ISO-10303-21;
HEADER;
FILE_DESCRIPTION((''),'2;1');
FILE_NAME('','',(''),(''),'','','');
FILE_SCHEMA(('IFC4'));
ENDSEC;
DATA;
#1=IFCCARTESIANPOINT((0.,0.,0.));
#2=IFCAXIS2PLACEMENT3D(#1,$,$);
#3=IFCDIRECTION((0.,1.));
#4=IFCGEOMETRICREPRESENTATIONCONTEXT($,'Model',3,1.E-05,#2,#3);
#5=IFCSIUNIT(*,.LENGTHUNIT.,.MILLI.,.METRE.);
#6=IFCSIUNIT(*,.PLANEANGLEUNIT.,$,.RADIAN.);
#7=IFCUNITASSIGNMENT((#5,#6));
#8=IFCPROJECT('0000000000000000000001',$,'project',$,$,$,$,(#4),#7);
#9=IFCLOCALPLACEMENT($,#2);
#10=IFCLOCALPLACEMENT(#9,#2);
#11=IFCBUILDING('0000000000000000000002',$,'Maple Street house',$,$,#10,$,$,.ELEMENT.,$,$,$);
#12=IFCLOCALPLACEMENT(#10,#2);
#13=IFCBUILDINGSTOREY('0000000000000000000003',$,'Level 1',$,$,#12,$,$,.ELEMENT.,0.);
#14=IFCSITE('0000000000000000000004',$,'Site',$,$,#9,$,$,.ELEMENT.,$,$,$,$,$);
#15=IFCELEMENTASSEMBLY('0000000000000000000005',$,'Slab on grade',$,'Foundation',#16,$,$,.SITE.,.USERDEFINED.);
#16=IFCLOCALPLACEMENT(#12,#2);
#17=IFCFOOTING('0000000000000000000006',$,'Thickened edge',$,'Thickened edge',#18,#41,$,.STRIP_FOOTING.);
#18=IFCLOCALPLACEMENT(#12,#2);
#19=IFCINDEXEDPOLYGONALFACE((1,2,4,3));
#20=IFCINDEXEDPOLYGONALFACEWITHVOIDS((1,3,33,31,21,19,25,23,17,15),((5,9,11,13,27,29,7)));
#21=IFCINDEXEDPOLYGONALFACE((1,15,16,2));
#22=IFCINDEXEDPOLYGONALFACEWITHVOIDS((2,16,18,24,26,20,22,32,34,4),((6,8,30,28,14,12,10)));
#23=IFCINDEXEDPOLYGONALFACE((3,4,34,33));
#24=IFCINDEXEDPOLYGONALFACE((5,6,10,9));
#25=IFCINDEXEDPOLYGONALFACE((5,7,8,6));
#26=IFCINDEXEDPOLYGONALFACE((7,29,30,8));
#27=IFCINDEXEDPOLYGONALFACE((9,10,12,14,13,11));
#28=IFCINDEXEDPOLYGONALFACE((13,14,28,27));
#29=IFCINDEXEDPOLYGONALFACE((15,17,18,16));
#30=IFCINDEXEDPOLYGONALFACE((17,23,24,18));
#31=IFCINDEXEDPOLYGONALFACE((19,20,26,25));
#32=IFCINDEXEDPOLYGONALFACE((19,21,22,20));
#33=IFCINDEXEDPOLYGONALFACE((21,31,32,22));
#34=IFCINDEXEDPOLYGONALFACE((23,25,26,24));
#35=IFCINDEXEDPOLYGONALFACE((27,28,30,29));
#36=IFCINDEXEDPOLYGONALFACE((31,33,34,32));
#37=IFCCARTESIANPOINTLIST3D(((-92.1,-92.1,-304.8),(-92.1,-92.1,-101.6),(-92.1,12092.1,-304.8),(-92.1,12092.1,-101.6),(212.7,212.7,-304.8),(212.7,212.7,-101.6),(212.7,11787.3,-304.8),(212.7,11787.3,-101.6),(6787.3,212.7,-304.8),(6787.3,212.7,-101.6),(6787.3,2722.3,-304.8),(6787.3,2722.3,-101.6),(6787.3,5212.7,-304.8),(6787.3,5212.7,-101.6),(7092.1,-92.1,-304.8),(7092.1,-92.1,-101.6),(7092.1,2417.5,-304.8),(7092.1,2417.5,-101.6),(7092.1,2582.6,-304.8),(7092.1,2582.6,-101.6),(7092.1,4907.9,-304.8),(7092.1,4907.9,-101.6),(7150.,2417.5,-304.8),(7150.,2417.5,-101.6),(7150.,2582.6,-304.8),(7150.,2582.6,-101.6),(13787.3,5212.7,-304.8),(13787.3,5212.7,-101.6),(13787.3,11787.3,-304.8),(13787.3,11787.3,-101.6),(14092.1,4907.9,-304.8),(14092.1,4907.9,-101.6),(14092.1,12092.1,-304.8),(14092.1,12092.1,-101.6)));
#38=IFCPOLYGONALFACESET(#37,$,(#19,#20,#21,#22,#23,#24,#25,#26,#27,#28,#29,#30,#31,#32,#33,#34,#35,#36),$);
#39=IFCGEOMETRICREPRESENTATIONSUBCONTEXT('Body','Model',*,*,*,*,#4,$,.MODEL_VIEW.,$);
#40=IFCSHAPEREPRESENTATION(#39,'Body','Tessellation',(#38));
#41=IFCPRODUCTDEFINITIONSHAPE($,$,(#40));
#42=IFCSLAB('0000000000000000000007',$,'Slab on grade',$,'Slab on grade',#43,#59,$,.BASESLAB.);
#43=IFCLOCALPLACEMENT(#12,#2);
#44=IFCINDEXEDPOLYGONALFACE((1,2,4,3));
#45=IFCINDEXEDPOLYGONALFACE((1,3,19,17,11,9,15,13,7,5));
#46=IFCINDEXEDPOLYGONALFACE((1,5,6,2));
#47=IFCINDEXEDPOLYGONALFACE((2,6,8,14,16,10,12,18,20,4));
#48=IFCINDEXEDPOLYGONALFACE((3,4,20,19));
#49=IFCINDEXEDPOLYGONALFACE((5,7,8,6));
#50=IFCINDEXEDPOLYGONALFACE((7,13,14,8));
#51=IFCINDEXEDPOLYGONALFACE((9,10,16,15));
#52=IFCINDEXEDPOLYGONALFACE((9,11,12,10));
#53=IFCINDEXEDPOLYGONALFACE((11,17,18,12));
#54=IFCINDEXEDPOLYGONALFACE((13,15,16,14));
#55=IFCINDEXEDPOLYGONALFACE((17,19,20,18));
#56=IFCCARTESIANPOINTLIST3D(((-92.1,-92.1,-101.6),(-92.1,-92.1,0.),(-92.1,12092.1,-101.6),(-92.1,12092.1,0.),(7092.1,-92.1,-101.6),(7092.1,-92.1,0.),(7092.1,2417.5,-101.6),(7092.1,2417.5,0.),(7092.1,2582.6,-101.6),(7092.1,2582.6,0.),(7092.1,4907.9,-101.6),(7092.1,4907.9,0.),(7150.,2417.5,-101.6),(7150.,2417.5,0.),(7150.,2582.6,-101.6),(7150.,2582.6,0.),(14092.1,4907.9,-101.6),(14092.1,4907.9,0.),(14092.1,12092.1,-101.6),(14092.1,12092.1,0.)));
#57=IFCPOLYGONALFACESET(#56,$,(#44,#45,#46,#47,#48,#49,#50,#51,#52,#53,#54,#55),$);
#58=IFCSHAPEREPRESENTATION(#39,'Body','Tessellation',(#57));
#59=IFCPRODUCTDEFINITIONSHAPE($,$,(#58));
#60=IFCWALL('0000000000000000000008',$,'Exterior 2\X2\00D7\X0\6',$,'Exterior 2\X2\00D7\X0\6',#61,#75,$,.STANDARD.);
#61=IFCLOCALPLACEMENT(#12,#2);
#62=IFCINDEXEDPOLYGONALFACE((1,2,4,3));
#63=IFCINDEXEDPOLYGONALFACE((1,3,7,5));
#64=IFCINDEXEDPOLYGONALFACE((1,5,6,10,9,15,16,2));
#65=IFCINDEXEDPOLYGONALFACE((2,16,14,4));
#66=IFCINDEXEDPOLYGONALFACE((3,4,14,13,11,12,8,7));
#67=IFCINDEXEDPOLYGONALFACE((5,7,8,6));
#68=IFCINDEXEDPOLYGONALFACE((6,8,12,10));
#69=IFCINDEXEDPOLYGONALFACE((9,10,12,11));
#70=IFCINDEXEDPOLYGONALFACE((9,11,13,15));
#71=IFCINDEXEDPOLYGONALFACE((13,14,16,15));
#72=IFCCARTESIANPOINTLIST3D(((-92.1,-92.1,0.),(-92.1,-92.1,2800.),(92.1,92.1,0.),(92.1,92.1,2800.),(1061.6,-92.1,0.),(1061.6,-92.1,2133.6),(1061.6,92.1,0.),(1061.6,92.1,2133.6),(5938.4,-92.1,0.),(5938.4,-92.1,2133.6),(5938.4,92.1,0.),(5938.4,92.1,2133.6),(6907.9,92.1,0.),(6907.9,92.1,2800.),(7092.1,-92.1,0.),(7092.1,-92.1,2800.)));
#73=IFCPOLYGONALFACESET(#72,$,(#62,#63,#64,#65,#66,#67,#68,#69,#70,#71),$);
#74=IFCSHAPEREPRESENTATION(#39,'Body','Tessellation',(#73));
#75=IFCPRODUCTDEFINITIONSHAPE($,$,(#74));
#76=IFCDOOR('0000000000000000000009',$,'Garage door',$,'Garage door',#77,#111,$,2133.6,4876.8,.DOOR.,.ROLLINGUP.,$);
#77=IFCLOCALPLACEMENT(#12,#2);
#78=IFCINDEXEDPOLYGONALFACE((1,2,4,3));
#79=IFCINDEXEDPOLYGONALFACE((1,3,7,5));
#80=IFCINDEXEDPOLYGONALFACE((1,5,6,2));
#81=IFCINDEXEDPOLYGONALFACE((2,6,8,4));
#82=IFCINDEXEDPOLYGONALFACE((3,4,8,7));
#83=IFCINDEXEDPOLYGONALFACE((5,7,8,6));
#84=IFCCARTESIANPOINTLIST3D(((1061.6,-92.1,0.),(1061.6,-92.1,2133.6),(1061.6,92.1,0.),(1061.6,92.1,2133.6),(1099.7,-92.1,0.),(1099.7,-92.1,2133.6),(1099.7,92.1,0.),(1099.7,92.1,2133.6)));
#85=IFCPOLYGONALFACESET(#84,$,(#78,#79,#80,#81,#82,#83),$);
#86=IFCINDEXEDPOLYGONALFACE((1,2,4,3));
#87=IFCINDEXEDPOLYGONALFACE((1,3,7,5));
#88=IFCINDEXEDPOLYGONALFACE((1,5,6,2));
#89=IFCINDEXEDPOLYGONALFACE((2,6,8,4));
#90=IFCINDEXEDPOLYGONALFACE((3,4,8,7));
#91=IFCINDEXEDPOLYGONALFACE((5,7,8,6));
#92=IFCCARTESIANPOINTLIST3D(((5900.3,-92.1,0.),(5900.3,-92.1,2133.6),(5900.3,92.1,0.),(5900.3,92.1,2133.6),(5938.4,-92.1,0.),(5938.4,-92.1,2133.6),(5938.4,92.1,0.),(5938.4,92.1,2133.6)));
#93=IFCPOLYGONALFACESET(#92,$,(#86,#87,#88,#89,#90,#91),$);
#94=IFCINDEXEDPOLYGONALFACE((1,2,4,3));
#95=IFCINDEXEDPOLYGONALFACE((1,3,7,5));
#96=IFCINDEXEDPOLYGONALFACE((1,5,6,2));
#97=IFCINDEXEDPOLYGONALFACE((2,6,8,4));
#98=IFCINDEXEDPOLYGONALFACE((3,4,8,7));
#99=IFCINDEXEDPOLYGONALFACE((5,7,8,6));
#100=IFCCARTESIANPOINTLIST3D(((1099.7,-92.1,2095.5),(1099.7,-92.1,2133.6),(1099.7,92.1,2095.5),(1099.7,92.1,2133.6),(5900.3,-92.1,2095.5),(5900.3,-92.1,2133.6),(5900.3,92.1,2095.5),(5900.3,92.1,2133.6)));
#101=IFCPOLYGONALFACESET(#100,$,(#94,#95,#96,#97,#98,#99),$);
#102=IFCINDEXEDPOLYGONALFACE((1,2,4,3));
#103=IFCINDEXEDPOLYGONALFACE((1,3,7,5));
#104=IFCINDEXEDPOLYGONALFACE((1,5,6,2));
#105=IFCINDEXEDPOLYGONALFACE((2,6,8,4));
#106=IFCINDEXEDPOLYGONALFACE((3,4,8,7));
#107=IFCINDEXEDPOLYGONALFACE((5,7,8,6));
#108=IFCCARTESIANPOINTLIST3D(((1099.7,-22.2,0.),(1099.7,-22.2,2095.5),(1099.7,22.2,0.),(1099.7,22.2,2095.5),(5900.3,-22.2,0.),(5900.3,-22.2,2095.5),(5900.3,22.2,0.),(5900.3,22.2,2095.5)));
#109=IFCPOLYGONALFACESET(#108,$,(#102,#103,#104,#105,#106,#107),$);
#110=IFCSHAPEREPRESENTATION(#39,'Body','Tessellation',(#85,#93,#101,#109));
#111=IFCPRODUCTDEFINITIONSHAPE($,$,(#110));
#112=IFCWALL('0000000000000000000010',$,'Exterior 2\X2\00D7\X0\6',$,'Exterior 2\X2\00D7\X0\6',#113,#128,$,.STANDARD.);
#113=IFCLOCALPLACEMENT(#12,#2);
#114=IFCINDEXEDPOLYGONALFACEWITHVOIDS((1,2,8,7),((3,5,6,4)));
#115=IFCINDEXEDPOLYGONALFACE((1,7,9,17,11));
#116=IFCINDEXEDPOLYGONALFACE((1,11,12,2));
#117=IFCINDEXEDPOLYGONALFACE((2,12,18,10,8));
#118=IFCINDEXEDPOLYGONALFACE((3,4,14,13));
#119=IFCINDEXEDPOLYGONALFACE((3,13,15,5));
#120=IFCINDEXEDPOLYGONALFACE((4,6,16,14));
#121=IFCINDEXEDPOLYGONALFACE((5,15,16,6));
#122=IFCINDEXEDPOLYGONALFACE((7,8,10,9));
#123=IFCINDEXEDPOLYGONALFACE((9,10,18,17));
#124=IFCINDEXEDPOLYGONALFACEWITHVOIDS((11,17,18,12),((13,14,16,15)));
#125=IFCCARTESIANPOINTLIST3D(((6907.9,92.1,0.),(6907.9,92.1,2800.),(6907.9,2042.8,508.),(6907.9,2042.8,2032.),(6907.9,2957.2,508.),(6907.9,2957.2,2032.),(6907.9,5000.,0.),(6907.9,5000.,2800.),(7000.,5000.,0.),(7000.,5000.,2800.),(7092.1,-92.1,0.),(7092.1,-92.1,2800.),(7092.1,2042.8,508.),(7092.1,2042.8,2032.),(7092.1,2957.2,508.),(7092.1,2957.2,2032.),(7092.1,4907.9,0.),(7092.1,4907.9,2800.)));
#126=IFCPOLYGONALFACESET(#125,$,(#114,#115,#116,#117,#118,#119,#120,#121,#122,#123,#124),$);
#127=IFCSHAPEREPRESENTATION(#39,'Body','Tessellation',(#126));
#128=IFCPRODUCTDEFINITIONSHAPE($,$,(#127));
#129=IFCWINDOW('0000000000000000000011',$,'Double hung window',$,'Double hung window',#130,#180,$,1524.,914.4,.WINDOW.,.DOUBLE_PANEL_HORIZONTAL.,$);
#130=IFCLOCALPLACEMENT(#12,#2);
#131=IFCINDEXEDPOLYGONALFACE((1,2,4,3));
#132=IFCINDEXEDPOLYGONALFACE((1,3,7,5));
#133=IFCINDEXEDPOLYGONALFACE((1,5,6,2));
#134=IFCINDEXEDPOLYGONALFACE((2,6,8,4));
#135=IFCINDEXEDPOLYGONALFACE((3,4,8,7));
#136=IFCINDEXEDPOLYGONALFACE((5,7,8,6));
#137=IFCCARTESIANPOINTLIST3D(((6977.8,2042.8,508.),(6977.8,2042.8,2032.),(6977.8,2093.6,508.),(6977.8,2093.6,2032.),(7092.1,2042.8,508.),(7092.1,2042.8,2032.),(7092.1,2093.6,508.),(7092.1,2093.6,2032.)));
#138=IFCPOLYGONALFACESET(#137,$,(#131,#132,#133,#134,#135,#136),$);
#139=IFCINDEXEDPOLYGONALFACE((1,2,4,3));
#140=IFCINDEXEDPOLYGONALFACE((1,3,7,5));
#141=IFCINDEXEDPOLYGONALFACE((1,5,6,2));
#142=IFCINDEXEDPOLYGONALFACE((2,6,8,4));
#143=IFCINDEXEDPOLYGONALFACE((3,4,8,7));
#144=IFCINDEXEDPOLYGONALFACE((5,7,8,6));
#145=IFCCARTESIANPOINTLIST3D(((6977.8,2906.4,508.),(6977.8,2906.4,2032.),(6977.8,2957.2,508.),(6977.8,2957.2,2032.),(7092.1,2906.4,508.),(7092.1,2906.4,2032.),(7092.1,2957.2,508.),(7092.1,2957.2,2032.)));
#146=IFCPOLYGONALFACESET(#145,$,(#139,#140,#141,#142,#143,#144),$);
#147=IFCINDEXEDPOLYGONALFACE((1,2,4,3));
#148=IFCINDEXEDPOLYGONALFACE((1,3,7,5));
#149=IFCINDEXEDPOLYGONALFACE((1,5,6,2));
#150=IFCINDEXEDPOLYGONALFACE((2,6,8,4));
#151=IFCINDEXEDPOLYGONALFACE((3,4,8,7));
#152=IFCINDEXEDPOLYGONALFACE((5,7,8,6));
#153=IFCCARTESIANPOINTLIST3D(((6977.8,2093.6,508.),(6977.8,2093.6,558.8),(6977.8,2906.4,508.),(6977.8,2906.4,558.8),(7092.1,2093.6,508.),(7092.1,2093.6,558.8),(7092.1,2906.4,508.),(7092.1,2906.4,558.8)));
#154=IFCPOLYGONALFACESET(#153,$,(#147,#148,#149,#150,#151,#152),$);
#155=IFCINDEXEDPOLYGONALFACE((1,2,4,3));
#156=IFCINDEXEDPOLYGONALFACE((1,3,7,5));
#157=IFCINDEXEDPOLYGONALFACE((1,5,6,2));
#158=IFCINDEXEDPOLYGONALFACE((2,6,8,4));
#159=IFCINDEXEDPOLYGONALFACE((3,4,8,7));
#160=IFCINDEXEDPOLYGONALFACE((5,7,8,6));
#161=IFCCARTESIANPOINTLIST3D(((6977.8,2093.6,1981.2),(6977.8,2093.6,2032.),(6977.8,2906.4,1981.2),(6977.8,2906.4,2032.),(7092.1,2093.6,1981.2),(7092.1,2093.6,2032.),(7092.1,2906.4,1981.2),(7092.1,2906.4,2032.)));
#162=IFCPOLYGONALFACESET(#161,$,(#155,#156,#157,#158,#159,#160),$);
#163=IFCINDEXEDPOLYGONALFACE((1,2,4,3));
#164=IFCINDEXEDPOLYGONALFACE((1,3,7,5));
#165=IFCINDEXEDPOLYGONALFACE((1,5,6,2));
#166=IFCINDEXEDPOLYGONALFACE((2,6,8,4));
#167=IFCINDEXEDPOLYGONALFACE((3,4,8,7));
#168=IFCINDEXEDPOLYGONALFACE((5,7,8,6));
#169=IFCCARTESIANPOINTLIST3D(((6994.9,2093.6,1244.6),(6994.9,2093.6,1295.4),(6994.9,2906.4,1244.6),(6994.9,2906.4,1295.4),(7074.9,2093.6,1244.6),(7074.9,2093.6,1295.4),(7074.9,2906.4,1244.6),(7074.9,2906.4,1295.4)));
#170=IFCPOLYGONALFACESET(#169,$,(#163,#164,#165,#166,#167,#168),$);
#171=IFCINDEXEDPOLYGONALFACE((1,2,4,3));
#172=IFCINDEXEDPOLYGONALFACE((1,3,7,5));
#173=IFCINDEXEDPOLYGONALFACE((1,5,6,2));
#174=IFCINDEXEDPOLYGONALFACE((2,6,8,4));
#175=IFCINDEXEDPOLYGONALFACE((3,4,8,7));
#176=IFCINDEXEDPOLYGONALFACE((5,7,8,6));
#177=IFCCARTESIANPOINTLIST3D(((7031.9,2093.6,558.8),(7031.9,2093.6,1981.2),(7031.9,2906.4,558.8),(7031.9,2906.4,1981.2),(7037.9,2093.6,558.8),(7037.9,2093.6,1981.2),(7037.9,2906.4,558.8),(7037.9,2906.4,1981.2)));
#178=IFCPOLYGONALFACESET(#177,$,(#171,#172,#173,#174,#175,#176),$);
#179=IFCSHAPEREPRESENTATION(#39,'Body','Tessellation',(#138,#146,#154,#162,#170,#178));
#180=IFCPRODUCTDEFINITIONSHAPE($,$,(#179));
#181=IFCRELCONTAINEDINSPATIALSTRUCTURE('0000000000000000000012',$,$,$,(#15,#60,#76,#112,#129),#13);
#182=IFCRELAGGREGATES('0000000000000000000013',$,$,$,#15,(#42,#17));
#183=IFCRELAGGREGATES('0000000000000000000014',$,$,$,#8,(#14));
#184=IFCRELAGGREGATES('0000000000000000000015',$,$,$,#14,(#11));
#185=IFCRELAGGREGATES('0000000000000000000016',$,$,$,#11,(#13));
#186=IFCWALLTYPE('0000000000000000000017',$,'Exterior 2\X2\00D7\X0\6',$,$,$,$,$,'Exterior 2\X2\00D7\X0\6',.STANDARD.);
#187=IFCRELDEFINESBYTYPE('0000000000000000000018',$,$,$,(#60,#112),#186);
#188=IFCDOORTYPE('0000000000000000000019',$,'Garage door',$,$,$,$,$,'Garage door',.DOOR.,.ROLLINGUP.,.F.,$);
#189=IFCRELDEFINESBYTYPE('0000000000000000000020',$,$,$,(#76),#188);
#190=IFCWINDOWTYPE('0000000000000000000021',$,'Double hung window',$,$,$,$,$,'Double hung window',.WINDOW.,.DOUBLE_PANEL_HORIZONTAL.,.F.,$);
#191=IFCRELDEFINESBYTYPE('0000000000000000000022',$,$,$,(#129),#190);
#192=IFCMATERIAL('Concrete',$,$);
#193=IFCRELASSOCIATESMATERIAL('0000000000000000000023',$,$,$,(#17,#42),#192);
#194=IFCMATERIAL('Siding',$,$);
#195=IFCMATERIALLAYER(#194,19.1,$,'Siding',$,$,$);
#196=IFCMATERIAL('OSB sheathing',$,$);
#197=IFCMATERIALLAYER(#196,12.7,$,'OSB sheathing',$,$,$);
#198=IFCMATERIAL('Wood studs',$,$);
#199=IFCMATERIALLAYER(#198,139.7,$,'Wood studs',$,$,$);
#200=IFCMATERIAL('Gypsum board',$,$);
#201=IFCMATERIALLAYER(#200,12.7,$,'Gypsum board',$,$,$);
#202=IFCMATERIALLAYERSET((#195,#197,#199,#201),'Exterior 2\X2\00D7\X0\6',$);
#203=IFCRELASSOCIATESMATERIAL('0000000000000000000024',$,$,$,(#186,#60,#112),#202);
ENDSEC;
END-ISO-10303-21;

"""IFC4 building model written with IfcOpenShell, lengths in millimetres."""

from ifc_helpers import new_model, si_unit, direction, frame, origin, origin_with_axes, place, context, subcontext, project, spatial, polyline, outline, extrude, material, layer, layer_set, layer_usage, type_object, element, fill, aggregate, save


model = new_model("IFC4")

# Units and contexts
model_context = context("Model", 3, precision=1e-05, world=origin(), true_north=direction((0.0, 1.0)))
body_context = subcontext(model_context, "Body", "Model", "MODEL_VIEW")
ifc_project = project(units=[si_unit("LENGTHUNIT", "METRE", prefix="MILLI"), si_unit("PLANEANGLEUNIT", "RADIAN")], contexts=[model_context])

# Site, building, storey
site_placement = place(None, origin())
site = spatial("IfcSite", under=ifc_project, at=site_placement, Name="Site", CompositionType="ELEMENT")
building_placement = place(site_placement, origin())
building = spatial("IfcBuilding", under=site, at=building_placement, Name="Maple Street house", CompositionType="ELEMENT")
storey_placement = place(building_placement, origin())
storey = spatial("IfcBuildingStorey", under=building, at=storey_placement, Name="Level 1", CompositionType="ELEMENT", Elevation=0.0)

# Element assembly, footing, slab
assembly_placement = place(storey_placement, origin_with_axes())
assembly = element("IfcElementAssembly", 1, at=assembly_placement, inside=storey, Name="Slab on grade", ObjectType="Foundation", AssemblyPlace="SITE", PredefinedType="USERDEFINED")
ifc_material_1 = material(Name="Concrete")
footing_placement = place(storey_placement, origin_with_axes())
footing = element("IfcFooting", 2, at=footing_placement, material=ifc_material_1, Name="Thickened edge", ObjectType="Thickened edge", PredefinedType="STRIP_FOOTING", context=body_context, shape_type="SweptSolid", body=[
    extrude(outline(polyline([(7092.1, 2417.5), (7150.0, 2417.5), (7150.0, 2582.6), (7092.1, 2582.6), (7092.1, 4907.9), (14092.1, 4907.9), (14092.1, 12092.1), (-92.1, 12092.1), (-92.1, -92.1), (7092.1, -92.1), (7092.1, 2417.5)]), holes=[polyline([(6787.3, 2722.3), (6845.2, 2722.3), (6845.2, 2277.8), (6787.3, 2277.8), (6787.3, 5212.7), (13787.3, 5212.7), (13787.3, 11787.3), (212.7, 11787.3), (212.7, 212.7), (6787.3, 212.7), (6787.3, 2722.3)])]), frame((0.0, 0.0, -304.8)), (0.0, 0.0, 1.0), 203.2),
])
slab_placement = place(storey_placement, origin_with_axes())
slab = element("IfcSlab", 3, at=slab_placement, material=ifc_material_1, Name="Slab on grade", ObjectType="Slab on grade", PredefinedType="BASESLAB", context=body_context, shape_type="SweptSolid", body=[
    extrude(outline(polyline([(7092.1, 2417.5), (7150.0, 2417.5), (7150.0, 2582.6), (7092.1, 2582.6), (7092.1, 4907.9), (14092.1, 4907.9), (14092.1, 12092.1), (-92.1, 12092.1), (-92.1, -92.1), (7092.1, -92.1), (7092.1, 2417.5)])), frame((0.0, 0.0, -101.6)), (0.0, 0.0, 1.0), 101.6),
])
aggregate(assembly, [slab, footing])

# Wall, opening, door
ifc_material_2 = material(Name="Siding")
ifc_layer_1 = layer(ifc_material_2, 19.1, Name="Siding")
ifc_material_3 = material(Name="OSB sheathing")
ifc_layer_2 = layer(ifc_material_3, 12.7, Name="OSB sheathing")
ifc_material_4 = material(Name="Wood studs")
ifc_layer_3 = layer(ifc_material_4, 139.7, Name="Wood studs")
ifc_material_5 = material(Name="Gypsum board")
ifc_layer_4 = layer(ifc_material_5, 12.7, Name="Gypsum board")
ifc_layer_set_1 = layer_set([ifc_layer_1, ifc_layer_2, ifc_layer_3, ifc_layer_4], Name="Exterior 2×6")
ifc_layer_usage_1 = layer_usage(ifc_layer_set_1, "AXIS2", "POSITIVE", -92.1)
wall_type_1 = type_object("IfcWallType", Name="Exterior 2×6", ElementType="Exterior 2×6", PredefinedType="STANDARD", material=ifc_layer_set_1)
wall_1_placement = place(storey_placement, frame((0.0, 0.0, 0.0), z_axis=(0.0, 0.0, 1.0), x_axis=(1.0, 0.0, 0.0)))
wall_1 = element("IfcWall", 4, at=wall_1_placement, inside=storey, type_object=wall_type_1, material=ifc_layer_usage_1, Name="Exterior 2×6", ObjectType="Exterior 2×6", PredefinedType="STANDARD", context=body_context, shape_type="SweptSolid", body=[
    extrude(outline(polyline([(-92.1, -92.1), (7092.1, -92.1), (6907.9, 92.1), (92.1, 92.1), (-92.1, -92.1)])), origin(), (0.0, 0.0, 1.0), 2800.0),
])
opening_1_placement = place(wall_1_placement, frame((1061.6, 0.0, 0.0), z_axis=(0.0, 0.0, 1.0), x_axis=(1.0, 0.0, 0.0)))
opening_1 = element("IfcOpeningElement", 5, at=opening_1_placement, cuts=wall_1, PredefinedType="OPENING", context=body_context, shape_type="SweptSolid", body=[
    extrude(outline(polyline([(0.0, -102.1), (4876.8, -102.1), (4876.8, 102.1), (0.0, 102.1), (0.0, -102.1)])), origin(), (0.0, 0.0, 1.0), 2133.6),
])
door_type_1 = type_object("IfcDoorType", Name="Garage door", ElementType="Garage door", OperationType="ROLLINGUP", ParameterTakesPrecedence=False, PredefinedType="DOOR")
door_1_placement = place(opening_1_placement, origin_with_axes())
door_1 = element("IfcDoor", 6, at=door_1_placement, inside=storey, type_object=door_type_1, Name="Garage door", ObjectType="Garage door", OperationType="ROLLINGUP", OverallHeight=2133.6, OverallWidth=4876.8, PredefinedType="DOOR", context=body_context, shape_type="SweptSolid", body=[
    extrude(outline(polyline([(0.0, -92.1), (38.1, -92.1), (38.1, 92.1), (0.0, 92.1), (0.0, -92.1)])), origin(), (0.0, 0.0, 1.0), 2133.6),
    extrude(outline(polyline([(4838.7, -92.1), (4876.8, -92.1), (4876.8, 92.1), (4838.7, 92.1), (4838.7, -92.1)])), origin(), (0.0, 0.0, 1.0), 2133.6),
    extrude(outline(polyline([(38.1, -92.1), (4838.7, -92.1), (4838.7, 92.1), (38.1, 92.1), (38.1, -92.1)])), frame((0.0, 0.0, 2095.5)), (0.0, 0.0, 1.0), 38.1),
    extrude(outline(polyline([(38.1, -22.2), (4838.7, -22.2), (4838.7, 22.2), (38.1, 22.2), (38.1, -22.2)])), origin(), (0.0, 0.0, 1.0), 2095.5),
])
fill(opening_1, door_1)

# Wall, opening, window
ifc_layer_usage_2 = layer_usage(ifc_layer_set_1, "AXIS2", "POSITIVE", -92.1)
wall_2_placement = place(storey_placement, frame((7000.0, 0.0, 0.0), z_axis=(0.0, 0.0, 1.0), x_axis=(0.0, 1.0, 0.0)))
wall_2 = element("IfcWall", 7, at=wall_2_placement, inside=storey, type_object=wall_type_1, material=ifc_layer_usage_2, Name="Exterior 2×6", ObjectType="Exterior 2×6", PredefinedType="STANDARD", context=body_context, shape_type="SweptSolid", body=[
    extrude(outline(polyline([(-92.1, -92.1), (4907.9, -92.1), (5000.0, 0.0), (5000.0, 92.1), (92.1, 92.1), (-92.1, -92.1)])), origin(), (0.0, 0.0, 1.0), 2800.0),
])
opening_2_placement = place(wall_2_placement, frame((2042.8, 0.0, 508.0), z_axis=(0.0, 0.0, 1.0), x_axis=(1.0, 0.0, 0.0)))
opening_2 = element("IfcOpeningElement", 8, at=opening_2_placement, cuts=wall_2, PredefinedType="OPENING", context=body_context, shape_type="SweptSolid", body=[
    extrude(outline(polyline([(0.0, -102.1), (914.4, -102.1), (914.4, 102.1), (0.0, 102.1), (0.0, -102.1)])), origin(), (0.0, 0.0, 1.0), 1524.0),
])
window_type = type_object("IfcWindowType", Name="Double hung window", ElementType="Double hung window", ParameterTakesPrecedence=False, PartitioningType="DOUBLE_PANEL_HORIZONTAL", PredefinedType="WINDOW")
window_1_placement = place(opening_2_placement, origin_with_axes())
window_1 = element("IfcWindow", 9, at=window_1_placement, inside=storey, type_object=window_type, Name="Double hung window", ObjectType="Double hung window", OverallHeight=1524.0, OverallWidth=914.4, PartitioningType="DOUBLE_PANEL_HORIZONTAL", PredefinedType="WINDOW", context=body_context, shape_type="SweptSolid", body=[
    extrude(outline(polyline([(0.0, -92.1), (50.8, -92.1), (50.8, 22.2), (0.0, 22.2), (0.0, -92.1)])), origin(), (0.0, 0.0, 1.0), 1524.0),
    extrude(outline(polyline([(863.6, -92.1), (914.4, -92.1), (914.4, 22.2), (863.6, 22.2), (863.6, -92.1)])), origin(), (0.0, 0.0, 1.0), 1524.0),
    extrude(outline(polyline([(50.8, -92.1), (863.6, -92.1), (863.6, 22.2), (50.8, 22.2), (50.8, -92.1)])), origin(), (0.0, 0.0, 1.0), 50.8),
    extrude(outline(polyline([(50.8, -92.1), (863.6, -92.1), (863.6, 22.2), (50.8, 22.2), (50.8, -92.1)])), frame((0.0, 0.0, 1473.2)), (0.0, 0.0, 1.0), 50.8),
    extrude(outline(polyline([(50.8, -74.9), (863.6, -74.9), (863.6, 5.1), (50.8, 5.1), (50.8, -74.9)])), frame((0.0, 0.0, 736.6)), (0.0, 0.0, 1.0), 50.8),
    extrude(outline(polyline([(50.8, -37.9), (863.6, -37.9), (863.6, -31.9), (50.8, -31.9), (50.8, -37.9)])), frame((0.0, 0.0, 50.8)), (0.0, 0.0, 1.0), 1422.4),
])
fill(opening_2, window_1)

save(model, "model.ifc")
